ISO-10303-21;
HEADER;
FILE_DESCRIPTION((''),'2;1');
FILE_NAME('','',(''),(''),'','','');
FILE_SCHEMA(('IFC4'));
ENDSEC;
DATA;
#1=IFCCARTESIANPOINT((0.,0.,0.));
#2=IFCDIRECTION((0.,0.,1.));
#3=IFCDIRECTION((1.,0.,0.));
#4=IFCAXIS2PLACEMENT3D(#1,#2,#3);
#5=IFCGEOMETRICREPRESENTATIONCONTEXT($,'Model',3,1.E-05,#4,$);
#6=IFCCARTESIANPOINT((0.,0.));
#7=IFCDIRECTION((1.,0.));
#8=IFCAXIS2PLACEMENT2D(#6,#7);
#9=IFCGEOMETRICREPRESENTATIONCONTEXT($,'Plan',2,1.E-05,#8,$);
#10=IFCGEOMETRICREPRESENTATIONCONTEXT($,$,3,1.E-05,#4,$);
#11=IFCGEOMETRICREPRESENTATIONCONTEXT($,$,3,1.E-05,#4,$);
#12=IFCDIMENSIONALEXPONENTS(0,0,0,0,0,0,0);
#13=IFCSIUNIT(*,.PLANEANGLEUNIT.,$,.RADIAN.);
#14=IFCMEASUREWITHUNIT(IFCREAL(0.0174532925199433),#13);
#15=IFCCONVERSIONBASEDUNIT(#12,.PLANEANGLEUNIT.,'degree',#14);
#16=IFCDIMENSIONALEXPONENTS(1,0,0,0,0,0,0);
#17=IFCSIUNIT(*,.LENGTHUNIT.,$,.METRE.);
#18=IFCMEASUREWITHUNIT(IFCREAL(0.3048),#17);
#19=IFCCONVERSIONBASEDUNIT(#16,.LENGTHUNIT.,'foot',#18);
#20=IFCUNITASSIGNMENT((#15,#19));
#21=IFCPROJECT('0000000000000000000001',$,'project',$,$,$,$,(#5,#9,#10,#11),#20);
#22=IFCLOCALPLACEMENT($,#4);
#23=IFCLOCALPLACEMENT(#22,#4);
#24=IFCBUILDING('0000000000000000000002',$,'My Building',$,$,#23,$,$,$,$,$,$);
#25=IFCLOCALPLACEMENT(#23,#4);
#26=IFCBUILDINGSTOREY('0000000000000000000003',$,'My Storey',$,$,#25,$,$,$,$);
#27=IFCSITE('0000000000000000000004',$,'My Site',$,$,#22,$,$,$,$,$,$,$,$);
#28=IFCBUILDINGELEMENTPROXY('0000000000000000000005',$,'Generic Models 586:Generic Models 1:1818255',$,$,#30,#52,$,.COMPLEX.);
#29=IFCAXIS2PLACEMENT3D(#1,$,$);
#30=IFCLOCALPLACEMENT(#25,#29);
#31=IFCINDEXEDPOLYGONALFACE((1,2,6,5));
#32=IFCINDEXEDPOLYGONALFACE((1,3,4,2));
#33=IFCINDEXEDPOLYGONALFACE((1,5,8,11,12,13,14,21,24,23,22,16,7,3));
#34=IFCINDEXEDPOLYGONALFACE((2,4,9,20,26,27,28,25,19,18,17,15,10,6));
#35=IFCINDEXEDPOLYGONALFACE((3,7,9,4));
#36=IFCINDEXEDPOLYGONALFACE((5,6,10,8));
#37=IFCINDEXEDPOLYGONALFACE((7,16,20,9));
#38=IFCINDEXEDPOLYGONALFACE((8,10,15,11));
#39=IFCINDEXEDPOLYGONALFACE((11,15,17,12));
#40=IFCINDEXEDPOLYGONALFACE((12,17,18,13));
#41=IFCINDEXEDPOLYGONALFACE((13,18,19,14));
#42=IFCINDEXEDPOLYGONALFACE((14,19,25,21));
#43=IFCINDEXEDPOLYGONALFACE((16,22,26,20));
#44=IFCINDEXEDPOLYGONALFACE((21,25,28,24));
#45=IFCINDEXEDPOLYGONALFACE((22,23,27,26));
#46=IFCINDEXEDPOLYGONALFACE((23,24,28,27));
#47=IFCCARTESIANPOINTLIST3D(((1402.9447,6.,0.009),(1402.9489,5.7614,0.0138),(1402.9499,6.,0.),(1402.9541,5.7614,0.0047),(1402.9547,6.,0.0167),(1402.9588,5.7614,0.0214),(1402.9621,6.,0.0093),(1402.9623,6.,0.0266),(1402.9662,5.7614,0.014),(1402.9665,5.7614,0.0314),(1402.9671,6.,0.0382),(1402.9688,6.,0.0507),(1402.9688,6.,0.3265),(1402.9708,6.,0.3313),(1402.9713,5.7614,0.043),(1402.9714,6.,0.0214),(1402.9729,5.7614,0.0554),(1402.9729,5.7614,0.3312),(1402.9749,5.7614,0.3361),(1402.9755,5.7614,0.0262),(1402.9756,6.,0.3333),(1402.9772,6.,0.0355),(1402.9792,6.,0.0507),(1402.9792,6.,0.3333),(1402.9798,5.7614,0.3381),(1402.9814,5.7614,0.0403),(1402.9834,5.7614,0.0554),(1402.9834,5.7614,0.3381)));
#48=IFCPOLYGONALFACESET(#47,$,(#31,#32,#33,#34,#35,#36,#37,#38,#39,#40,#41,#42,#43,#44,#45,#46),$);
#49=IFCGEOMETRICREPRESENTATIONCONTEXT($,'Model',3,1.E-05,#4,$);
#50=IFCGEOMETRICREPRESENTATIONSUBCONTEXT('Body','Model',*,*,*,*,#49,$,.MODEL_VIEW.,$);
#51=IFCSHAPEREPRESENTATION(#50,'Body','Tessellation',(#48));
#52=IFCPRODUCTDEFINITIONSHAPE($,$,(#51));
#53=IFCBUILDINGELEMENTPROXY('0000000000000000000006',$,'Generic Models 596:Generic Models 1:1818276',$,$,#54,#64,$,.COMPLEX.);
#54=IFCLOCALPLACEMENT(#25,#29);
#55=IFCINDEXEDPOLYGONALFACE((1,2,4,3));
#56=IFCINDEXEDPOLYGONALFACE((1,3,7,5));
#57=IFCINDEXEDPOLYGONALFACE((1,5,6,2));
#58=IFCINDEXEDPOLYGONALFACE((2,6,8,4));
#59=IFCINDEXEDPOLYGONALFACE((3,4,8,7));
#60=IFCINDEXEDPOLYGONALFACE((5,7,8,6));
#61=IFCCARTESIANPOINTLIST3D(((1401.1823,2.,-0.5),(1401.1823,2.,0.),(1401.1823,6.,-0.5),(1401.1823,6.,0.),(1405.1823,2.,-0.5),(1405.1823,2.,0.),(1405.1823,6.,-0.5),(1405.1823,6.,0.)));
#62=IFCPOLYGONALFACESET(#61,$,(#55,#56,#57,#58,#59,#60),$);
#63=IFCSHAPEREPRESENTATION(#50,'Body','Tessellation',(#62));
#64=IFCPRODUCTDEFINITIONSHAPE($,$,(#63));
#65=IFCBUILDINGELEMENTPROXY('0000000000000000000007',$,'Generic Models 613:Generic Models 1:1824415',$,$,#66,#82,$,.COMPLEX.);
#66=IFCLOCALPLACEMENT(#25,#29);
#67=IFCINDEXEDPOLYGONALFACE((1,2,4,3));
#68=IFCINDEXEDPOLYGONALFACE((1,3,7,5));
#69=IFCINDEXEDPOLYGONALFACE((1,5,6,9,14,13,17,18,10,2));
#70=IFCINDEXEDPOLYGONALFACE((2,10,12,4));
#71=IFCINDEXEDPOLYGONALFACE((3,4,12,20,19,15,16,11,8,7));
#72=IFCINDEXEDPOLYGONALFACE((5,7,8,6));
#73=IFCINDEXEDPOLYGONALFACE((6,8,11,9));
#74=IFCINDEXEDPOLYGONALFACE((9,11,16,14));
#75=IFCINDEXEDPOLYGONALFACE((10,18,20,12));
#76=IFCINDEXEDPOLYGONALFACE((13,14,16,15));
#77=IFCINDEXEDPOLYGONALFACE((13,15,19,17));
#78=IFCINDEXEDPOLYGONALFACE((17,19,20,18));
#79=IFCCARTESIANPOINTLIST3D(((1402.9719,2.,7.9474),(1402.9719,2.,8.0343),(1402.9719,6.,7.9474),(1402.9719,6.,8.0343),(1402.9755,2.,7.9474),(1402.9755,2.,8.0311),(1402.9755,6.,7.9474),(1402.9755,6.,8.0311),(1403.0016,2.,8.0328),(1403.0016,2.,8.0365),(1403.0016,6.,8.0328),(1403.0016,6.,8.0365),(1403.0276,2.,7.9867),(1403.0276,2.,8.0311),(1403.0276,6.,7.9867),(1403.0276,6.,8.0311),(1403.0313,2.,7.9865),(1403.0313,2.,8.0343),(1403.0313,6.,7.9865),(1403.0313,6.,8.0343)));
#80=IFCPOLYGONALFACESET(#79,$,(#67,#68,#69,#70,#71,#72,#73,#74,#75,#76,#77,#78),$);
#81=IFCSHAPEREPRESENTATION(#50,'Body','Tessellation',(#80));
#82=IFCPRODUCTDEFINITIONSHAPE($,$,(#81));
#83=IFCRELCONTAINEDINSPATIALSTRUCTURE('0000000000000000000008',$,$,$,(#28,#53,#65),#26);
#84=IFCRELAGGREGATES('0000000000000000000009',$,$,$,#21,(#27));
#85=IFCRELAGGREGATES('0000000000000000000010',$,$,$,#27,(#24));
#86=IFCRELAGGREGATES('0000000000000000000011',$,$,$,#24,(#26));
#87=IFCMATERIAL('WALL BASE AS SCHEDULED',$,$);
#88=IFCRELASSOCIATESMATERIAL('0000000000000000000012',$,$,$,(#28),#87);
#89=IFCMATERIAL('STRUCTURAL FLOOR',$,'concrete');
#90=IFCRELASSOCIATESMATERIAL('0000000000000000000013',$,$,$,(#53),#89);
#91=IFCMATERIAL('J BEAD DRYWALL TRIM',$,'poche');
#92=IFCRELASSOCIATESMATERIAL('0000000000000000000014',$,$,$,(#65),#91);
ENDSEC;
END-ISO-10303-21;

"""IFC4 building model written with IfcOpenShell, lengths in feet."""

from ifc_helpers import new_model, entity, si_unit, converted_unit, frame, origin_with_axes, origin_2d_with_axis, place, context, subcontext, project, spatial, polyline, outline, extrude, material, element, save


model = new_model("IFC4")

# Units and contexts
model_context_1 = context("Model", 3, precision=1e-05, world=origin_with_axes())
plan_context = context("Plan", 2, precision=1e-05, world=origin_2d_with_axis())
model_context_2 = context("Model", 3, precision=1e-05, world=origin_with_axes())
context_of_model_1 = context(None, 3, precision=1e-05, world=origin_with_axes())
context_of_model_2 = context(None, 3, precision=1e-05, world=origin_with_axes())
body_context = subcontext(model_context_2, "Body", "Model", "MODEL_VIEW")
ifc_project = project(units=[converted_unit("PLANEANGLEUNIT", "degree", entity("IfcReal", 0.0174532925199433), si_unit("PLANEANGLEUNIT", "RADIAN"), dimensions=[0, 0, 0, 0, 0, 0, 0]), converted_unit("LENGTHUNIT", "foot", entity("IfcReal", 0.3048), si_unit("LENGTHUNIT", "METRE"), dimensions=[1, 0, 0, 0, 0, 0, 0])], contexts=[model_context_1, plan_context, context_of_model_1, context_of_model_2])

# Site, building, storey
site_placement = place(None, origin_with_axes())
site = spatial("IfcSite", under=ifc_project, at=site_placement, Name="My Site")
building_placement = place(site_placement, origin_with_axes())
building = spatial("IfcBuilding", under=site, at=building_placement, Name="My Building")
storey_placement = place(building_placement, origin_with_axes())
storey = spatial("IfcBuildingStorey", under=building, at=storey_placement, Name="My Storey")

# Building element proxies
ifc_material_1 = material(Name="WALL BASE AS SCHEDULED")
proxy_1_placement = place(storey_placement, frame((1402.9447, 6.0, 0.0), z_axis=(0.0, -1.0, 0.0), x_axis=(0.0, 0.0, 1.0)))
element("IfcBuildingElementProxy", 1, at=proxy_1_placement, inside=storey, material=ifc_material_1, Name="Generic Models 586:Generic Models 1:1818255", PredefinedType="COMPLEX", context=body_context, shape_type="SweptSolid", body=[
    extrude(outline(polyline([(0.0748, 0.0), (0.0624, -0.0017), (-0.2134, -0.0039), (-0.2182, -0.0059), (-0.2202, -0.0108), (-0.2202, -0.0144), (0.0625, -0.0122), (0.0776, -0.01), (0.0917, -0.0041), (0.1037, 0.0053), (0.1129, 0.0175), (0.1039, 0.0226), (0.0963, 0.0126), (0.0864, 0.0049), (0.0748, 0.0)])), frame((0.113, -0.0218, 0.0), z_axis=(0.0, 0.0, -1.0), x_axis=(-0.99997, -0.007803, 0.0)), (-0.019684, -0.017536, -0.999652), 0.2387),
])
ifc_material_2 = material(Name="STRUCTURAL FLOOR", Category="concrete")
proxy_2_placement = place(storey_placement, frame((1401.1823, 6.0, -0.5), z_axis=(0.0, -1.0, 0.0), x_axis=(0.0, 0.0, 1.0)))
element("IfcBuildingElementProxy", 2, at=proxy_2_placement, inside=storey, material=ifc_material_2, Name="Generic Models 596:Generic Models 1:1818276", PredefinedType="COMPLEX", context=body_context, shape_type="SweptSolid", body=[
    extrude(outline(polyline([(-0.25, -2.0), (0.25, -2.0), (0.25, 2.0), (-0.25, 2.0), (-0.25, -2.0)])), frame((0.25, -2.0, 0.0), z_axis=(0.0, 0.0, -1.0), x_axis=(-1.0, 0.0, 0.0)), (0.0, 0.0, -1.0), 4.0),
])
ifc_material_3 = material(Name="J BEAD DRYWALL TRIM", Category="poche")
proxy_3_placement = place(storey_placement, frame((1402.9719, 6.0, 7.9474), z_axis=(0.0, -1.0, 0.0), x_axis=(0.0, 0.0, 1.0)))
element("IfcBuildingElementProxy", 3, at=proxy_3_placement, inside=storey, material=ifc_material_3, Name="Generic Models 613:Generic Models 1:1824415", PredefinedType="COMPLEX", context=body_context, shape_type="SweptSolid", body=[
    extrude(outline(polyline([(-0.0243, 0.026), (0.0594, 0.026), (0.0594, 0.0297), (-0.0275, 0.0297), (-0.0296, 0.0), (-0.0275, -0.0297), (0.0203, -0.0297), (0.0201, -0.026), (-0.0243, -0.026), (-0.026, 0.0), (-0.0243, 0.026)])), frame((0.0594, -0.0297, 0.0), z_axis=(0.0, 0.0, -1.0), x_axis=(-1.0, 0.0, 0.0)), (0.0, 0.0, -1.0), 4.0),
])

save(model, "model.ifc")
